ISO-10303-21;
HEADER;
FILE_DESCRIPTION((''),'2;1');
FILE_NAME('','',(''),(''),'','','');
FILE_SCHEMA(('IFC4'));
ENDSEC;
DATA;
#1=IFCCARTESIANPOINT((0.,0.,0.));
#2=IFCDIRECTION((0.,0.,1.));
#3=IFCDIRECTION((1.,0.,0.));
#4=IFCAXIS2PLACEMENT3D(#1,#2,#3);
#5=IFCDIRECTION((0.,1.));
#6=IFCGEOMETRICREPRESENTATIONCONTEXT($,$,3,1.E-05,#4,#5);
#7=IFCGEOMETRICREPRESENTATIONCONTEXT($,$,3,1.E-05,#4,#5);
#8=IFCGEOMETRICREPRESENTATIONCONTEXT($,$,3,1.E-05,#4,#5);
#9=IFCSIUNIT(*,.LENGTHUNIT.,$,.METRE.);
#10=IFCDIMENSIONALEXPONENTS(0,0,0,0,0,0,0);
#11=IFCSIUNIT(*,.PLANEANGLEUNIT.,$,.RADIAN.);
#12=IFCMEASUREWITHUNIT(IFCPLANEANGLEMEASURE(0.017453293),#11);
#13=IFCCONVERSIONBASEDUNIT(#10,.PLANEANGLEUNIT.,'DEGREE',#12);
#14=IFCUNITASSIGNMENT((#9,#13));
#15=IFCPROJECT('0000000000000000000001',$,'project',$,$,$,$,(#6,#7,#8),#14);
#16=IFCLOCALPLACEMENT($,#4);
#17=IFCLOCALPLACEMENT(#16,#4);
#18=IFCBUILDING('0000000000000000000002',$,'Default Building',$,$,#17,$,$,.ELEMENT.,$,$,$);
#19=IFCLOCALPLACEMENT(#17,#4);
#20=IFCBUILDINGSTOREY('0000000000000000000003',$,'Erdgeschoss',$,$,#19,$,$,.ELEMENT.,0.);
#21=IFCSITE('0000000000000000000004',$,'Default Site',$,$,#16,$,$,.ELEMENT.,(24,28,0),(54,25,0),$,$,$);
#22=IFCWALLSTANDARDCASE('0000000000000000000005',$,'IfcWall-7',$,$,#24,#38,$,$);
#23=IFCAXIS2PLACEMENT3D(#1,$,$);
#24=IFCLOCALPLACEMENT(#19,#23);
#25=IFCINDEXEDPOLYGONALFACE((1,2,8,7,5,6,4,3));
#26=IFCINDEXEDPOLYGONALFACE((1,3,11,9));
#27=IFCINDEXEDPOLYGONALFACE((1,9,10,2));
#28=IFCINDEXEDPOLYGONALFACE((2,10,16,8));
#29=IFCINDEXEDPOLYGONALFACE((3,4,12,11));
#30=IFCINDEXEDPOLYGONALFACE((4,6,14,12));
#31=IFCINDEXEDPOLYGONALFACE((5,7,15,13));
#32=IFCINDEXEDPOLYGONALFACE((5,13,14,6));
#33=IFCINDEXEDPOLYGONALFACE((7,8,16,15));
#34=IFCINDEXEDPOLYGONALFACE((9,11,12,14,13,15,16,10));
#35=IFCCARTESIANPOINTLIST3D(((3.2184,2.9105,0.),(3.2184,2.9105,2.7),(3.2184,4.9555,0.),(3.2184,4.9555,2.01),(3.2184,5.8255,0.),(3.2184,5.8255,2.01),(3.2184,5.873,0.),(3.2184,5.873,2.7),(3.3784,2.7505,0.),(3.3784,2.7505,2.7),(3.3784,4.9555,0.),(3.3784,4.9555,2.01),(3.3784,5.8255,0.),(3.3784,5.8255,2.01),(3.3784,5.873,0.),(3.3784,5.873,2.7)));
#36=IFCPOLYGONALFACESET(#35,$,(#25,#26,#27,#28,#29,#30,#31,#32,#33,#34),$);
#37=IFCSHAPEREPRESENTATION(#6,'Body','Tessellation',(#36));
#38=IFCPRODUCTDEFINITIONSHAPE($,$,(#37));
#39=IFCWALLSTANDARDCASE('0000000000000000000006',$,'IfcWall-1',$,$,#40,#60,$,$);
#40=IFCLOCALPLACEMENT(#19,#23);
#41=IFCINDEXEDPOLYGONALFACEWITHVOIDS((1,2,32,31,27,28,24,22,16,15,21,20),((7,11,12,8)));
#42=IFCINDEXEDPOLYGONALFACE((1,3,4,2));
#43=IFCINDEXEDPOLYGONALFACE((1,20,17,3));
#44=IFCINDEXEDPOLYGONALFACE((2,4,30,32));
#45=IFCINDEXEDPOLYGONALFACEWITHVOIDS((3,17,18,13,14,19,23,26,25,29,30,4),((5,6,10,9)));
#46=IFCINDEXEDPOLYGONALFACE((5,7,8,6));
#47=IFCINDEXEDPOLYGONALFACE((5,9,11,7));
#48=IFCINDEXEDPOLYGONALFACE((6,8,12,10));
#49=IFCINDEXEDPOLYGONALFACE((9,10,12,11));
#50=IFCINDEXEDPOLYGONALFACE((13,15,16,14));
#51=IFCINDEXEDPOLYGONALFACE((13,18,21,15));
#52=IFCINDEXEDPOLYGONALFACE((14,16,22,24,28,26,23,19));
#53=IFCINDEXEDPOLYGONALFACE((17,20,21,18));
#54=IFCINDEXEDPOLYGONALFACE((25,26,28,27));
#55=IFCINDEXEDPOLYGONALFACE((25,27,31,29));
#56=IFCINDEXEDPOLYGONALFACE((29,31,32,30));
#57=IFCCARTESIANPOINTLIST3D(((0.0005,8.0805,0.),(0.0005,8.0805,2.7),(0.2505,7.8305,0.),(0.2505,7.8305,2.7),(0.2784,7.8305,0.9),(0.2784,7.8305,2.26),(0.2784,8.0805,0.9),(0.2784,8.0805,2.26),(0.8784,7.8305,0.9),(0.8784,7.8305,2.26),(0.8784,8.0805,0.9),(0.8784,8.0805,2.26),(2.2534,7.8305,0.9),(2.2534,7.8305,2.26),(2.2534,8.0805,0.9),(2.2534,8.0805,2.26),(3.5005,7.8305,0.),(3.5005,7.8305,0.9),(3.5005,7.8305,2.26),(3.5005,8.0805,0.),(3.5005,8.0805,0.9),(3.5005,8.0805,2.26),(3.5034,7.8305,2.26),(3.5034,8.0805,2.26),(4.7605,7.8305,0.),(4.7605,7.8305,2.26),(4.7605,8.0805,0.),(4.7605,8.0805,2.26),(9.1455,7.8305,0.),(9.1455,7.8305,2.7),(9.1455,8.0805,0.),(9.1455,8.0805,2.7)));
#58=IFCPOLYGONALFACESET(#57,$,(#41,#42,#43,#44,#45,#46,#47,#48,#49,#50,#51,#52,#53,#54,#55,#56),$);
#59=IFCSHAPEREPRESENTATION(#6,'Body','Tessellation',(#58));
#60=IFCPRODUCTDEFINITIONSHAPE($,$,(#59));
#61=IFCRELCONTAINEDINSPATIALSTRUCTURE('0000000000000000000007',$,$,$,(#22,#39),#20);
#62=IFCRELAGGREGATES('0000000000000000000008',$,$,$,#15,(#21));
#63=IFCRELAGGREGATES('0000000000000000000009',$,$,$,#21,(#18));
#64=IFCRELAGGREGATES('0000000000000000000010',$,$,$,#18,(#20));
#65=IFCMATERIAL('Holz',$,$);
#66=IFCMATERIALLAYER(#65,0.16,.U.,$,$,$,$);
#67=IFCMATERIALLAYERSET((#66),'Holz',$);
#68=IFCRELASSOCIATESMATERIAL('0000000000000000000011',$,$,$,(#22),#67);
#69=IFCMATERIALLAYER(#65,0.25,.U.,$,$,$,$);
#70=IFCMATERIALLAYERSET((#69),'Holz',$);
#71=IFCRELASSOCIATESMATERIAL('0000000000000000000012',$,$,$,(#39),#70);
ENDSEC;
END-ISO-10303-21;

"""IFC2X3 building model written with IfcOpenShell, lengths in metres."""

from ifc_helpers import new_model, entity, si_unit, converted_unit, direction, frame, frame_2d, origin_with_axes, place, context, project, spatial, polyline, rectangle, outline, extrude, material, layer, layer_set, layer_usage, element, save


model = new_model("IFC2X3")

# Units and contexts
context_of_model_1 = context(None, 3, precision=1e-05, world=origin_with_axes(), true_north=direction((0.0, 1.0)))
context_of_model_2 = context(None, 3, precision=1e-05, world=origin_with_axes(), true_north=direction((0.0, 1.0)))
context_of_model_3 = context(None, 3, precision=1e-05, world=origin_with_axes(), true_north=direction((0.0, 1.0)))
ifc_project = project(units=[si_unit("LENGTHUNIT", "METRE"), converted_unit("PLANEANGLEUNIT", "DEGREE", entity("IfcPlaneAngleMeasure", 0.017453293), si_unit("PLANEANGLEUNIT", "RADIAN"), dimensions=[0, 0, 0, 0, 0, 0, 0])], contexts=[context_of_model_1, context_of_model_2, context_of_model_3])

# Site, building, storey
site_placement = place(None, origin_with_axes())
site = spatial("IfcSite", under=ifc_project, at=site_placement, Name="Default Site", CompositionType="ELEMENT", RefLatitude=(24, 28, 0), RefLongitude=(54, 25, 0))
building_placement = place(site_placement, origin_with_axes())
building = spatial("IfcBuilding", under=site, at=building_placement, Name="Default Building", CompositionType="ELEMENT")
storey_placement = place(building_placement, origin_with_axes())
storey = spatial("IfcBuildingStorey", under=building, at=storey_placement, Name="Erdgeschoss", CompositionType="ELEMENT", Elevation=0.0)

# Shared definitions
ifc_material_1 = material(Name="Holz")

# Wall, opening
ifc_layer_1 = layer(ifc_material_1, 0.16, ventilated="UNKNOWN")
ifc_layer_set_1 = layer_set([ifc_layer_1], Name="Holz")
ifc_layer_usage_1 = layer_usage(ifc_layer_set_1, "AXIS2", "NEGATIVE", 0.0)
wall_1_placement = place(storey_placement, frame((3.2184, 2.9105, 0.0), z_axis=(0.0, 0.0, 1.0), x_axis=(0.0, 1.0, 0.0)))
wall_1 = element("IfcWallStandardCase", 1, at=wall_1_placement, inside=storey, material=ifc_layer_usage_1, Name="IfcWall-7", context=context_of_model_1, shape_type="SweptSolid", body=[
    extrude(outline(polyline([(-0.16, -0.16), (2.9625, -0.16), (2.9625, 0.0), (0.0, 0.0), (-0.16, -0.16)])), origin_with_axes(), (0.0, 0.0, 1.0), 2.7),
])
opening_1_placement = place(wall_1_placement, frame((2.48, -0.16, 0.0), z_axis=(0.0, 0.0, 1.0), x_axis=(1.0, 0.0, 0.0)))
element("IfcOpeningElement", 2, at=opening_1_placement, cuts=wall_1, context=context_of_model_1, shape_type="SweptSolid", body=[
    extrude(rectangle(XDim=2.01, YDim=0.87, at=frame_2d((0.0, 1.005), x_axis=(0.0, -1.0))), frame((0.0, 0.0, 0.0), z_axis=(0.0, 1.0, 0.0), x_axis=(-1.0, 0.0, 0.0)), (0.0, 0.0, 1.0), 0.16),
])

# Wall, openings
ifc_layer_2 = layer(ifc_material_1, 0.25, ventilated="UNKNOWN")
ifc_layer_set_2 = layer_set([ifc_layer_2], Name="Holz")
ifc_layer_usage_2 = layer_usage(ifc_layer_set_2, "AXIS2", "NEGATIVE", 0.0)
wall_2_placement = place(storey_placement, frame((0.0005, 8.0805, 0.0), z_axis=(0.0, 0.0, 1.0), x_axis=(1.0, 0.0, 0.0)))
wall_2 = element("IfcWallStandardCase", 3, at=wall_2_placement, inside=storey, material=ifc_layer_usage_2, Name="IfcWall-1", context=context_of_model_1, shape_type="SweptSolid", body=[
    extrude(outline(polyline([(0.25, -0.25), (9.145, -0.25), (9.145, 0.0), (0.0, 0.0), (0.25, -0.25)])), origin_with_axes(), (0.0, 0.0, 1.0), 2.7),
])
opening_2_placement = place(wall_2_placement, frame((4.13, -0.25, 0.0), z_axis=(0.0, 0.0, 1.0), x_axis=(1.0, 0.0, 0.0)))
element("IfcOpeningElement", 4, at=opening_2_placement, cuts=wall_2, context=context_of_model_1, shape_type="SweptSolid", body=[
    extrude(rectangle(XDim=2.26, YDim=1.26, at=frame_2d((0.0, 1.13), x_axis=(0.0, -1.0))), frame((0.0, 0.0, 0.0), z_axis=(0.0, 1.0, 0.0), x_axis=(-1.0, 0.0, 0.0)), (0.0, 0.0, 1.0), 0.25),
])
opening_3_placement = place(wall_2_placement, frame((0.5779, -0.25, 0.9), z_axis=(0.0, 0.0, 1.0), x_axis=(1.0, 0.0, 0.0)))
element("IfcOpeningElement", 5, at=opening_3_placement, cuts=wall_2, context=context_of_model_1, shape_type="SweptSolid", body=[
    extrude(rectangle(XDim=1.36, YDim=0.6, at=frame_2d((0.0, 0.68), x_axis=(0.0, -1.0))), frame((0.0, 0.0, 0.0), z_axis=(0.0, 1.0, 0.0), x_axis=(-1.0, 0.0, 0.0)), (0.0, 0.0, 1.0), 0.25),
])
opening_4_placement = place(wall_2_placement, frame((2.8779, -0.25, 0.9), z_axis=(0.0, 0.0, 1.0), x_axis=(1.0, 0.0, 0.0)))
element("IfcOpeningElement", 6, at=opening_4_placement, cuts=wall_2, context=context_of_model_1, shape_type="SweptSolid", body=[
    extrude(rectangle(XDim=1.36, YDim=1.25, at=frame_2d((0.0, 0.68), x_axis=(0.0, 1.0))), frame((0.0, 0.0, 0.0), z_axis=(0.0, 1.0, 0.0), x_axis=(-1.0, 0.0, 0.0)), (0.0, 0.0, 1.0), 0.25),
])

save(model, "model.ifc")
